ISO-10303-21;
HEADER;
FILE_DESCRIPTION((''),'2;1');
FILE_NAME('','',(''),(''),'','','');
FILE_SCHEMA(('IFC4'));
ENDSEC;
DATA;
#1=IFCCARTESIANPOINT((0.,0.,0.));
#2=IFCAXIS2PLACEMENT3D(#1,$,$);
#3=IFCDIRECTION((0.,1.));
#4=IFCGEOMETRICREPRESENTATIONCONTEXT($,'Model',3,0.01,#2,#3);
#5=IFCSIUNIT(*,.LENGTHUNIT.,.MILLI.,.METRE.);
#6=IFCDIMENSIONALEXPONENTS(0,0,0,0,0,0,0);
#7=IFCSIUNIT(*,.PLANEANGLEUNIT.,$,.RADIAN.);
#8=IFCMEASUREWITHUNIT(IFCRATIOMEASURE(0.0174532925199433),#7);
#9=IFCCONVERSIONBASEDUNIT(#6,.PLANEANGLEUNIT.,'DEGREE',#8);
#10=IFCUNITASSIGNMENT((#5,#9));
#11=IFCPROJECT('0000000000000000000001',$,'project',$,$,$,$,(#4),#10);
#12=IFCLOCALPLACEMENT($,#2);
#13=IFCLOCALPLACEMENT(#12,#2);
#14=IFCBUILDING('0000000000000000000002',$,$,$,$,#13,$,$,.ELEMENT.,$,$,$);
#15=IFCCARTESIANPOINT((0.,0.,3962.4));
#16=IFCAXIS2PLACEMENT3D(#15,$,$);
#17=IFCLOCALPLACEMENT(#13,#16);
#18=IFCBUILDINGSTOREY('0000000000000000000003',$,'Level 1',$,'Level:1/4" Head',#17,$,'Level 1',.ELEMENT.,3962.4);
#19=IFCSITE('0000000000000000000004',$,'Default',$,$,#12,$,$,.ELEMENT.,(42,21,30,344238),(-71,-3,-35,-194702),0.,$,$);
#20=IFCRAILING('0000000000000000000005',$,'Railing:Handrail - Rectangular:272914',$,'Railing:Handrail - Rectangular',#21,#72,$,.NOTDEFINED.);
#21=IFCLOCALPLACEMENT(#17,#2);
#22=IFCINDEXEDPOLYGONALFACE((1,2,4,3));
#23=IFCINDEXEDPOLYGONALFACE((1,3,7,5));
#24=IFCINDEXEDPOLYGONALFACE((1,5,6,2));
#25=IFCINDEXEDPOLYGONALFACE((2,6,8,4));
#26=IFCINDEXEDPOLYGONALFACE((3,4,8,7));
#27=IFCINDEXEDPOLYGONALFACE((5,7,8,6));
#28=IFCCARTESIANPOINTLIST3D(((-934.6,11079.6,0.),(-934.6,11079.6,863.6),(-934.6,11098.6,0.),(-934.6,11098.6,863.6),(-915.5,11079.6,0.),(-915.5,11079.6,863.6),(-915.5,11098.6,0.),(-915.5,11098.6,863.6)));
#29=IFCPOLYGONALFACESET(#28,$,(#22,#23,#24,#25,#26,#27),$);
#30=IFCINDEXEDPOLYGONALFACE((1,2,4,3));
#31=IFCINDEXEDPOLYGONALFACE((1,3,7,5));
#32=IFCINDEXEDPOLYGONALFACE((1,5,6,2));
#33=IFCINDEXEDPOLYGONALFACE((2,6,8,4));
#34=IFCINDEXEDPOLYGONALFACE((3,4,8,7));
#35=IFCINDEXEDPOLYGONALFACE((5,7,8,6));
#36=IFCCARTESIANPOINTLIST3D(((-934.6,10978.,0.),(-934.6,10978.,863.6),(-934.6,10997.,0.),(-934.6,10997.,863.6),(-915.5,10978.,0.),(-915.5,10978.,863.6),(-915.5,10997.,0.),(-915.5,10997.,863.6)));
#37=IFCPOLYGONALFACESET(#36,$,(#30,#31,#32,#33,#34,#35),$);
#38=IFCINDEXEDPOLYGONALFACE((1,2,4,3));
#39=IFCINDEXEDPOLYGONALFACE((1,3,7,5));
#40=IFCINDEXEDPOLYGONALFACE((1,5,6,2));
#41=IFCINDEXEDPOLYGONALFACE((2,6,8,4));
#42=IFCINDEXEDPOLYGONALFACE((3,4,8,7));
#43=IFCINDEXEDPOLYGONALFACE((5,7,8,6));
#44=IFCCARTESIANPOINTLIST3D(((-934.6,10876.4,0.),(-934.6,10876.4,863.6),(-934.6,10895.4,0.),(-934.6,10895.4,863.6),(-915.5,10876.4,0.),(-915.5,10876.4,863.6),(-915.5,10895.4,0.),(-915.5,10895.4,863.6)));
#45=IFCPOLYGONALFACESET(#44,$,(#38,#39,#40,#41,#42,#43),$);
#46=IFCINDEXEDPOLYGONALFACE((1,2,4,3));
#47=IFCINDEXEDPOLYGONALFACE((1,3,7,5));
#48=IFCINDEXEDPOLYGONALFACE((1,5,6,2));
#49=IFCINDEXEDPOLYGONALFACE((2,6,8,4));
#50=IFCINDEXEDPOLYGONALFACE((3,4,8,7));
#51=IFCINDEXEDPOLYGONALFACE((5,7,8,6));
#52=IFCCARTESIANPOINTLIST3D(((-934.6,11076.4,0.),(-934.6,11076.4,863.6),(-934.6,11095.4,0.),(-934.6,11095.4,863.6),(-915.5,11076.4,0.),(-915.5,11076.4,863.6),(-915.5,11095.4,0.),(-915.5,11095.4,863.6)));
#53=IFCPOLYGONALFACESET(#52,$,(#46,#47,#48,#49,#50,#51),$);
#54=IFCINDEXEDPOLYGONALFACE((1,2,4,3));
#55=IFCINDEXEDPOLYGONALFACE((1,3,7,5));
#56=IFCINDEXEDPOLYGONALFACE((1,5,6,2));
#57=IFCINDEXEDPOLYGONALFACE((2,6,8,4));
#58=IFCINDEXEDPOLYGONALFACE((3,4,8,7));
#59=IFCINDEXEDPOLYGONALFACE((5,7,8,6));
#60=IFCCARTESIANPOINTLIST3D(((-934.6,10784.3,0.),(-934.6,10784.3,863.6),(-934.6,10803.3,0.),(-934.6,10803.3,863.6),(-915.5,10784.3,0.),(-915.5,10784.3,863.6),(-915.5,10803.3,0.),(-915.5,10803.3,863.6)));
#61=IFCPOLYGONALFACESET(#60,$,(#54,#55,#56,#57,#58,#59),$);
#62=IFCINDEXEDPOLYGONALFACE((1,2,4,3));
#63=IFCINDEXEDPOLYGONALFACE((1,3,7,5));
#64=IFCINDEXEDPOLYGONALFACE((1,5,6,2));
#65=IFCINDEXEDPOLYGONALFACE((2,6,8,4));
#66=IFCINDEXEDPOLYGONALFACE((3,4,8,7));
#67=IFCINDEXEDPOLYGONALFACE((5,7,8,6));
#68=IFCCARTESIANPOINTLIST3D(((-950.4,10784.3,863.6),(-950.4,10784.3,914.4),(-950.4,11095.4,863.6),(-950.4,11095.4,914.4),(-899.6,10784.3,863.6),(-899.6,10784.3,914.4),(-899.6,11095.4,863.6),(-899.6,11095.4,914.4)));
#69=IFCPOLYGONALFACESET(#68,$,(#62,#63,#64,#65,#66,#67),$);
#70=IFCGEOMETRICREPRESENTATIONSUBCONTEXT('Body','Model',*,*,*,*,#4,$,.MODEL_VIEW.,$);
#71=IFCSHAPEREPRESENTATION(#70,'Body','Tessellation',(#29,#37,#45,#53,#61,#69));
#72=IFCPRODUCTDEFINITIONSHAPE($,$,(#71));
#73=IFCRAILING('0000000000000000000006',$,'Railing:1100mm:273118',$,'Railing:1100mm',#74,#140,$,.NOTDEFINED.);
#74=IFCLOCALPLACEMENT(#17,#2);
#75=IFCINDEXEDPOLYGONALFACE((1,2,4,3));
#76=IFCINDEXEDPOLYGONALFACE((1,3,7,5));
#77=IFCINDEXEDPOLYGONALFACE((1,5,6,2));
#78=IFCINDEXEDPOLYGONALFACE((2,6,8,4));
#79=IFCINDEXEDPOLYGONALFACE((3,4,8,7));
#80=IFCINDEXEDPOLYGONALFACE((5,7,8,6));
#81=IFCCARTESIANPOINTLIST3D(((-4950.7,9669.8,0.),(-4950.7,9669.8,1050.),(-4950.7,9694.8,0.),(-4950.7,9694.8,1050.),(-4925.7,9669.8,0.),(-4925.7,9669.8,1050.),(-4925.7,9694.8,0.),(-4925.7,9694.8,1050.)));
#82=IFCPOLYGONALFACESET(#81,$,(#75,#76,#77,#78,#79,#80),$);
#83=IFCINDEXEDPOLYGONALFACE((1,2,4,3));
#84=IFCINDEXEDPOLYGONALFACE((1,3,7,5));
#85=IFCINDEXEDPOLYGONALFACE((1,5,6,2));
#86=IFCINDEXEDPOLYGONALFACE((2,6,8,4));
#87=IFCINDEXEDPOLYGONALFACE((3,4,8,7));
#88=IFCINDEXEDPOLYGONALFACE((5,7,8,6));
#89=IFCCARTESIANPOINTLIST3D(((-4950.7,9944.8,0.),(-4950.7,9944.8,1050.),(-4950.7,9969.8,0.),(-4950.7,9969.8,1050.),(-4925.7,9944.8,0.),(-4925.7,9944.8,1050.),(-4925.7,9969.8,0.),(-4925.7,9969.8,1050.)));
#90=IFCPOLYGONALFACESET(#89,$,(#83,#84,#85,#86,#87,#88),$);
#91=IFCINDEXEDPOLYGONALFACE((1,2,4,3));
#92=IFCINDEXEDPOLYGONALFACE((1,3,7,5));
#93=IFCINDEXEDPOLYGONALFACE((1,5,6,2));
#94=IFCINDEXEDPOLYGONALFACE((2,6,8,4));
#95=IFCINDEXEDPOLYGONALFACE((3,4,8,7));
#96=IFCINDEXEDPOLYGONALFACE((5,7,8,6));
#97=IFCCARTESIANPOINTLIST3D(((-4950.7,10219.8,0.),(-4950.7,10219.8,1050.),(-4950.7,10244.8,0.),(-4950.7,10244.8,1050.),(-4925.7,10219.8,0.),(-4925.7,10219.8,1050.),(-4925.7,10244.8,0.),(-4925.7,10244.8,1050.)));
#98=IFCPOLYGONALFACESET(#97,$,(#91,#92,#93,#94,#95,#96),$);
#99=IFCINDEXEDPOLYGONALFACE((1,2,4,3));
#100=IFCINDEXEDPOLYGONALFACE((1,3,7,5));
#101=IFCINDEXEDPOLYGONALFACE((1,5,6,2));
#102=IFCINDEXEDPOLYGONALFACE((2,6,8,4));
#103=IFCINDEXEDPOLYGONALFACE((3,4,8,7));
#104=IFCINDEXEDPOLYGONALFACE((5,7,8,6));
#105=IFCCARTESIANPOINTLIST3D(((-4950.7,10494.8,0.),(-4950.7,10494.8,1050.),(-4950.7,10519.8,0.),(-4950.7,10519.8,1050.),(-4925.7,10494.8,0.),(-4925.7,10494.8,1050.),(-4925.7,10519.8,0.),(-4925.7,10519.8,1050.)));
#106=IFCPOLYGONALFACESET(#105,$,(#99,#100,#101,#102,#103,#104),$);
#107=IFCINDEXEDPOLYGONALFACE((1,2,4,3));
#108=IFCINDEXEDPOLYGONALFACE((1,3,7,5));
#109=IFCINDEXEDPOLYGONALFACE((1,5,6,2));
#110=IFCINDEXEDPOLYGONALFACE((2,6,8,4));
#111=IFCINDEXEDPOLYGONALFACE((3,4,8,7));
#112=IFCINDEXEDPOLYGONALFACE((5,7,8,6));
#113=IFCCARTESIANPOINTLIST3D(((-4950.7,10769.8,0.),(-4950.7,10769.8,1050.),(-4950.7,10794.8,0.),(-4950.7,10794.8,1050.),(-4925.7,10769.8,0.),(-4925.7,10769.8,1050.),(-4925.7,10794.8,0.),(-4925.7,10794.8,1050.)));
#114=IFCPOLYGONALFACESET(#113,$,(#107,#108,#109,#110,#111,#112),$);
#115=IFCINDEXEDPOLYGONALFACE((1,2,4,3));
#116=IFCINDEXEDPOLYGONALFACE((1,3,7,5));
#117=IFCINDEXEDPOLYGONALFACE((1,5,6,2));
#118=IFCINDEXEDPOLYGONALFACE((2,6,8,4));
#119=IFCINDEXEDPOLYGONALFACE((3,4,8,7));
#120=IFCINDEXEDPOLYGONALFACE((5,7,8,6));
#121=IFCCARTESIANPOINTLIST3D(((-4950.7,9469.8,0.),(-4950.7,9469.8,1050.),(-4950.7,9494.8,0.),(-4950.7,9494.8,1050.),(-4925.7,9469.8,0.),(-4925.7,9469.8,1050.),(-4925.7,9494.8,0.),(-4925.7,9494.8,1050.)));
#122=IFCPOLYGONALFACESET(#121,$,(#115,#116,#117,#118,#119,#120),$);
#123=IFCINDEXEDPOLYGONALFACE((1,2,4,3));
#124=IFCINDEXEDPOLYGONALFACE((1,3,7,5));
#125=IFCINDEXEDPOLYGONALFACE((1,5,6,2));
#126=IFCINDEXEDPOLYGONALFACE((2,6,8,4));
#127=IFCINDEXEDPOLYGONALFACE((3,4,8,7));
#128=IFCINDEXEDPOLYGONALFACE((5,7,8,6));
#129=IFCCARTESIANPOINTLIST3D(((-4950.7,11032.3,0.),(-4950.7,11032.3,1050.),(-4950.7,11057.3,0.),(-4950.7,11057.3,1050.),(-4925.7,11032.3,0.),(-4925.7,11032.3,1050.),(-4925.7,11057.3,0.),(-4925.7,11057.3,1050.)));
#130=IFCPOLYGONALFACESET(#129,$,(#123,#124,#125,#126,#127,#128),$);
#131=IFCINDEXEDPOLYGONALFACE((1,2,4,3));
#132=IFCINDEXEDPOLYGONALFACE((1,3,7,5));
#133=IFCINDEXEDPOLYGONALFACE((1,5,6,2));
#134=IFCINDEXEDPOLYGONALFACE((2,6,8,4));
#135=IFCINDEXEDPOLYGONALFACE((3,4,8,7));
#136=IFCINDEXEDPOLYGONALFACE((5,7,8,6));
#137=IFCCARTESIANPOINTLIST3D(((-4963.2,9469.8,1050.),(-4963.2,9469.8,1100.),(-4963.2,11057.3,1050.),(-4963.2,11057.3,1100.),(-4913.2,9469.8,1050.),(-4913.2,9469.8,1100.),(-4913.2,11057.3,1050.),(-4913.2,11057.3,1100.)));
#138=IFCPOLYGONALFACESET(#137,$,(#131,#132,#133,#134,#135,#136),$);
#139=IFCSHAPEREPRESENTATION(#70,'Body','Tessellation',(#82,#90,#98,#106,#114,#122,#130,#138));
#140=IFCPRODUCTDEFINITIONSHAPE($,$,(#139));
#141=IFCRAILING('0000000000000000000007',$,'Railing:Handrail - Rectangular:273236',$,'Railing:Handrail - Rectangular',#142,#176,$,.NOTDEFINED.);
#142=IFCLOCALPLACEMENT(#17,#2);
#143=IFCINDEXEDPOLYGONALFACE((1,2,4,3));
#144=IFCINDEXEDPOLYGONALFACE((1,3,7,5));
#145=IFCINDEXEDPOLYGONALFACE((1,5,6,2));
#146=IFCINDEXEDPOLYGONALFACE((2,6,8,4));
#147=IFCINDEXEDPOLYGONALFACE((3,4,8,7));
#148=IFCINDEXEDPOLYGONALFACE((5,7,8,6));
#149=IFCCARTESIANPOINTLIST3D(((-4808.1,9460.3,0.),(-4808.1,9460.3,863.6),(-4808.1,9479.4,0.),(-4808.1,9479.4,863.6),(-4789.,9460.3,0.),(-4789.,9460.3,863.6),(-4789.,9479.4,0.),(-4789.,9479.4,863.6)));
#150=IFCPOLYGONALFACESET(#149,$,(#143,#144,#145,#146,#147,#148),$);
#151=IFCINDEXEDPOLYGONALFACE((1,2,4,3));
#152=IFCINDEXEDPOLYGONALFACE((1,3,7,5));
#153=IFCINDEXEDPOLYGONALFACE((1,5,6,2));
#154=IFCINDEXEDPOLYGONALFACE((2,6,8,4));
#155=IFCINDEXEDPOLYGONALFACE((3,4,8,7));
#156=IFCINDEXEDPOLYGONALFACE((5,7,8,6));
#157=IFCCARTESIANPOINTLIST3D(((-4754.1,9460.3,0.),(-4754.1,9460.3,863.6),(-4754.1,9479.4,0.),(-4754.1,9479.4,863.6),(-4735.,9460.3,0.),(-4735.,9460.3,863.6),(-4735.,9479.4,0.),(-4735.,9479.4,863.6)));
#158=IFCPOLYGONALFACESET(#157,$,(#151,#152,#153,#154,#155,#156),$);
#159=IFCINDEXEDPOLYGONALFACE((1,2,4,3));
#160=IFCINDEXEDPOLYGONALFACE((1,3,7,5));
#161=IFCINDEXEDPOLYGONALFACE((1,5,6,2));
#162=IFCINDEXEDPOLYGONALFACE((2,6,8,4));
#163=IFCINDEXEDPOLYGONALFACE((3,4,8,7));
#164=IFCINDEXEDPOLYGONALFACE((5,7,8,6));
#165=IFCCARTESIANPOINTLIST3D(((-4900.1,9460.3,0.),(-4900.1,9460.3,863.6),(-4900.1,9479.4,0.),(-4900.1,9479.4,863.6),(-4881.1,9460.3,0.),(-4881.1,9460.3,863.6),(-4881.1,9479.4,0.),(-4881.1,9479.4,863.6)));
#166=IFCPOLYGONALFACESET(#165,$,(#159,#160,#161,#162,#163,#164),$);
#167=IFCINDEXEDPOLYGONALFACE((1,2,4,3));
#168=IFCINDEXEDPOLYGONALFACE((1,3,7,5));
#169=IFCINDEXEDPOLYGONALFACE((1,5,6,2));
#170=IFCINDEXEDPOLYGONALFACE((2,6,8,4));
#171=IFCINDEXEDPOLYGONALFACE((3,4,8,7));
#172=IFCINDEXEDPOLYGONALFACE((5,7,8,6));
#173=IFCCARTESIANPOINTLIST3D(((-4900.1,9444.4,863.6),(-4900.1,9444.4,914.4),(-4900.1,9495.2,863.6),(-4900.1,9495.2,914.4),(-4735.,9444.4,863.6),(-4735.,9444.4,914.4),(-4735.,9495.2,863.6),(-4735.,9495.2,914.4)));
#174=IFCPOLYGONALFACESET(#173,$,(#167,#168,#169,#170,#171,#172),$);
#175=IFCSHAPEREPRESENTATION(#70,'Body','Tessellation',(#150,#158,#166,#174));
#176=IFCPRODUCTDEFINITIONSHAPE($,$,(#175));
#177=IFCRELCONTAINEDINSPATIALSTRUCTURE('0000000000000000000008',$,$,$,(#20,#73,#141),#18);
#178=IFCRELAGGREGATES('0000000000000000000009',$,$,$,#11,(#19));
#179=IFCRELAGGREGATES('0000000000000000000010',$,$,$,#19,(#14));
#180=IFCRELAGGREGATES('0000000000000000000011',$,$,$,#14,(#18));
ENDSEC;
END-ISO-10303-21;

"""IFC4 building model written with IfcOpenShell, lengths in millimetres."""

from ifc_helpers import new_model, entity, si_unit, converted_unit, direction, frame, origin, place, context, subcontext, project, spatial, indexed_curve, outline, extrude, element, save


model = new_model("IFC4")

# Units and contexts
model_context = context("Model", 3, precision=0.01, world=origin(), true_north=direction((0.0, 1.0)))
body_context = subcontext(model_context, "Body", "Model", "MODEL_VIEW")
ifc_project = project(units=[si_unit("LENGTHUNIT", "METRE", prefix="MILLI"), converted_unit("PLANEANGLEUNIT", "DEGREE", entity("IfcRatioMeasure", 0.0174532925199433), si_unit("PLANEANGLEUNIT", "RADIAN"), dimensions=[0, 0, 0, 0, 0, 0, 0])], contexts=[model_context])

# Site, building, storey
site_placement = place(None, origin())
site = spatial("IfcSite", under=ifc_project, at=site_placement, Name="Default", CompositionType="ELEMENT", RefLatitude=(42, 21, 30, 344238), RefLongitude=(-71, -3, -35, -194702), RefElevation=0.0)
building_placement = place(site_placement, origin())
building = spatial("IfcBuilding", under=site, at=building_placement, CompositionType="ELEMENT")
storey_placement = place(building_placement, frame((0.0, 0.0, 3962.4)))
storey = spatial("IfcBuildingStorey", under=building, at=storey_placement, Name="Level 1", ObjectType="Level:1/4\" Head", LongName="Level 1", CompositionType="ELEMENT", Elevation=3962.4)

# Railings
railing_1_placement = place(storey_placement, origin())
element("IfcRailing", 1, at=railing_1_placement, inside=storey, Name="Railing:Handrail - Rectangular:272914", ObjectType="Railing:Handrail - Rectangular", PredefinedType="NOTDEFINED", context=body_context, shape_type="SweptSolid", body=[
    extrude(outline(indexed_curve([(-9.5, -9.5), (9.5, -9.5), (9.5, 9.5), (-9.5, 9.5), (-9.5, -9.5)], self_intersect=False)), frame((-925.0, 11089.1, 0.0), z_axis=(0.0, 0.0, 1.0), x_axis=(0.0, 1.0, 0.0)), (0.0, 0.0, 1.0), 863.6),
    extrude(outline(indexed_curve([(-9.5, -9.5), (9.5, -9.5), (9.5, 9.5), (-9.5, 9.5), (-9.5, -9.5)], self_intersect=False)), frame((-925.0, 10987.5, 0.0), z_axis=(0.0, 0.0, 1.0), x_axis=(0.0, 1.0, 0.0)), (0.0, 0.0, 1.0), 863.6),
    extrude(outline(indexed_curve([(-9.5, -9.5), (9.5, -9.5), (9.5, 9.5), (-9.5, 9.5), (-9.5, -9.5)], self_intersect=False)), frame((-925.0, 10885.9, 0.0), z_axis=(0.0, 0.0, 1.0), x_axis=(0.0, 1.0, 0.0)), (0.0, 0.0, 1.0), 863.6),
    extrude(outline(indexed_curve([(-9.5, -9.5), (9.5, -9.5), (9.5, 9.5), (-9.5, 9.5), (-9.5, -9.5)], self_intersect=False)), frame((-925.0, 11085.9, 0.0), z_axis=(0.0, 0.0, 1.0), x_axis=(0.0, 1.0, 0.0)), (0.0, 0.0, 1.0), 863.6),
    extrude(outline(indexed_curve([(-9.5, -9.5), (9.5, -9.5), (9.5, 9.5), (-9.5, 9.5), (-9.5, -9.5)], self_intersect=False)), frame((-925.0, 10793.8, 0.0), z_axis=(0.0, 0.0, 1.0), x_axis=(0.0, 1.0, 0.0)), (0.0, 0.0, 1.0), 863.6),
    extrude(outline(indexed_curve([(-155.6, -25.4), (155.6, -25.4), (155.6, 25.4), (-155.6, 25.4), (-155.6, -25.4)], self_intersect=False)), frame((-925.0, 10939.9, 863.6), z_axis=(0.0, 0.0, 1.0), x_axis=(0.0, 1.0, 0.0)), (0.0, 0.0, 1.0), 50.8),
])
railing_2_placement = place(storey_placement, origin())
element("IfcRailing", 2, at=railing_2_placement, inside=storey, Name="Railing:1100mm:273118", ObjectType="Railing:1100mm", PredefinedType="NOTDEFINED", context=body_context, shape_type="SweptSolid", body=[
    extrude(outline(indexed_curve([(-12.5, -12.5), (12.5, -12.5), (12.5, 12.5), (-12.5, 12.5), (-12.5, -12.5)], self_intersect=False)), frame((-4938.2, 9682.3, 0.0), z_axis=(0.0, 0.0, 1.0), x_axis=(0.0, -1.0, 0.0)), (0.0, 0.0, 1.0), 1050.0),
    extrude(outline(indexed_curve([(-12.5, -12.5), (12.5, -12.5), (12.5, 12.5), (-12.5, 12.5), (-12.5, -12.5)], self_intersect=False)), frame((-4938.2, 9957.3, 0.0), z_axis=(0.0, 0.0, 1.0), x_axis=(0.0, -1.0, 0.0)), (0.0, 0.0, 1.0), 1050.0),
    extrude(outline(indexed_curve([(-12.5, -12.5), (12.5, -12.5), (12.5, 12.5), (-12.5, 12.5), (-12.5, -12.5)], self_intersect=False)), frame((-4938.2, 10232.3, 0.0), z_axis=(0.0, 0.0, 1.0), x_axis=(0.0, -1.0, 0.0)), (0.0, 0.0, 1.0), 1050.0),
    extrude(outline(indexed_curve([(-12.5, -12.5), (12.5, -12.5), (12.5, 12.5), (-12.5, 12.5), (-12.5, -12.5)], self_intersect=False)), frame((-4938.2, 10507.3, 0.0), z_axis=(0.0, 0.0, 1.0), x_axis=(0.0, -1.0, 0.0)), (0.0, 0.0, 1.0), 1050.0),
    extrude(outline(indexed_curve([(-12.5, -12.5), (12.5, -12.5), (12.5, 12.5), (-12.5, 12.5), (-12.5, -12.5)], self_intersect=False)), frame((-4938.2, 10782.3, 0.0), z_axis=(0.0, 0.0, 1.0), x_axis=(0.0, -1.0, 0.0)), (0.0, 0.0, 1.0), 1050.0),
    extrude(outline(indexed_curve([(-12.5, -12.5), (12.5, -12.5), (12.5, 12.5), (-12.5, 12.5), (-12.5, -12.5)], self_intersect=False)), frame((-4938.2, 9482.3, 0.0), z_axis=(0.0, 0.0, 1.0), x_axis=(0.0, -1.0, 0.0)), (0.0, 0.0, 1.0), 1050.0),
    extrude(outline(indexed_curve([(-12.5, -12.5), (12.5, -12.5), (12.5, 12.5), (-12.5, 12.5), (-12.5, -12.5)], self_intersect=False)), frame((-4938.2, 11044.8, 0.0), z_axis=(0.0, 0.0, 1.0), x_axis=(0.0, -1.0, 0.0)), (0.0, 0.0, 1.0), 1050.0),
    extrude(outline(indexed_curve([(-793.7, -25.0), (793.7, -25.0), (793.7, 25.0), (-793.7, 25.0), (-793.7, -25.0)], self_intersect=False)), frame((-4938.2, 10263.6, 1050.0), z_axis=(0.0, 0.0, 1.0), x_axis=(0.0, -1.0, 0.0)), (0.0, 0.0, 1.0), 50.0),
])
railing_3_placement = place(storey_placement, origin())
element("IfcRailing", 3, at=railing_3_placement, inside=storey, Name="Railing:Handrail - Rectangular:273236", ObjectType="Railing:Handrail - Rectangular", PredefinedType="NOTDEFINED", context=body_context, shape_type="SweptSolid", body=[
    extrude(outline(indexed_curve([(-9.5, -9.5), (9.5, -9.5), (9.5, 9.5), (-9.5, 9.5), (-9.5, -9.5)], self_intersect=False)), frame((-4798.5, 9469.8, 0.0)), (0.0, 0.0, 1.0), 863.6),
    extrude(outline(indexed_curve([(-9.5, -9.5), (9.5, -9.5), (9.5, 9.5), (-9.5, 9.5), (-9.5, -9.5)], self_intersect=False)), frame((-4744.6, 9469.8, 0.0)), (0.0, 0.0, 1.0), 863.6),
    extrude(outline(indexed_curve([(-9.5, -9.5), (9.5, -9.5), (9.5, 9.5), (-9.5, 9.5), (-9.5, -9.5)], self_intersect=False)), frame((-4890.6, 9469.8, 0.0)), (0.0, 0.0, 1.0), 863.6),
    extrude(outline(indexed_curve([(-82.5, -25.4), (82.6, -25.4), (82.5, 25.4), (-82.5, 25.4), (-82.5, -25.4)], self_intersect=False)), frame((-4817.6, 9469.8, 863.6)), (0.0, 0.0, 1.0), 50.8),
])

save(model, "model.ifc")
